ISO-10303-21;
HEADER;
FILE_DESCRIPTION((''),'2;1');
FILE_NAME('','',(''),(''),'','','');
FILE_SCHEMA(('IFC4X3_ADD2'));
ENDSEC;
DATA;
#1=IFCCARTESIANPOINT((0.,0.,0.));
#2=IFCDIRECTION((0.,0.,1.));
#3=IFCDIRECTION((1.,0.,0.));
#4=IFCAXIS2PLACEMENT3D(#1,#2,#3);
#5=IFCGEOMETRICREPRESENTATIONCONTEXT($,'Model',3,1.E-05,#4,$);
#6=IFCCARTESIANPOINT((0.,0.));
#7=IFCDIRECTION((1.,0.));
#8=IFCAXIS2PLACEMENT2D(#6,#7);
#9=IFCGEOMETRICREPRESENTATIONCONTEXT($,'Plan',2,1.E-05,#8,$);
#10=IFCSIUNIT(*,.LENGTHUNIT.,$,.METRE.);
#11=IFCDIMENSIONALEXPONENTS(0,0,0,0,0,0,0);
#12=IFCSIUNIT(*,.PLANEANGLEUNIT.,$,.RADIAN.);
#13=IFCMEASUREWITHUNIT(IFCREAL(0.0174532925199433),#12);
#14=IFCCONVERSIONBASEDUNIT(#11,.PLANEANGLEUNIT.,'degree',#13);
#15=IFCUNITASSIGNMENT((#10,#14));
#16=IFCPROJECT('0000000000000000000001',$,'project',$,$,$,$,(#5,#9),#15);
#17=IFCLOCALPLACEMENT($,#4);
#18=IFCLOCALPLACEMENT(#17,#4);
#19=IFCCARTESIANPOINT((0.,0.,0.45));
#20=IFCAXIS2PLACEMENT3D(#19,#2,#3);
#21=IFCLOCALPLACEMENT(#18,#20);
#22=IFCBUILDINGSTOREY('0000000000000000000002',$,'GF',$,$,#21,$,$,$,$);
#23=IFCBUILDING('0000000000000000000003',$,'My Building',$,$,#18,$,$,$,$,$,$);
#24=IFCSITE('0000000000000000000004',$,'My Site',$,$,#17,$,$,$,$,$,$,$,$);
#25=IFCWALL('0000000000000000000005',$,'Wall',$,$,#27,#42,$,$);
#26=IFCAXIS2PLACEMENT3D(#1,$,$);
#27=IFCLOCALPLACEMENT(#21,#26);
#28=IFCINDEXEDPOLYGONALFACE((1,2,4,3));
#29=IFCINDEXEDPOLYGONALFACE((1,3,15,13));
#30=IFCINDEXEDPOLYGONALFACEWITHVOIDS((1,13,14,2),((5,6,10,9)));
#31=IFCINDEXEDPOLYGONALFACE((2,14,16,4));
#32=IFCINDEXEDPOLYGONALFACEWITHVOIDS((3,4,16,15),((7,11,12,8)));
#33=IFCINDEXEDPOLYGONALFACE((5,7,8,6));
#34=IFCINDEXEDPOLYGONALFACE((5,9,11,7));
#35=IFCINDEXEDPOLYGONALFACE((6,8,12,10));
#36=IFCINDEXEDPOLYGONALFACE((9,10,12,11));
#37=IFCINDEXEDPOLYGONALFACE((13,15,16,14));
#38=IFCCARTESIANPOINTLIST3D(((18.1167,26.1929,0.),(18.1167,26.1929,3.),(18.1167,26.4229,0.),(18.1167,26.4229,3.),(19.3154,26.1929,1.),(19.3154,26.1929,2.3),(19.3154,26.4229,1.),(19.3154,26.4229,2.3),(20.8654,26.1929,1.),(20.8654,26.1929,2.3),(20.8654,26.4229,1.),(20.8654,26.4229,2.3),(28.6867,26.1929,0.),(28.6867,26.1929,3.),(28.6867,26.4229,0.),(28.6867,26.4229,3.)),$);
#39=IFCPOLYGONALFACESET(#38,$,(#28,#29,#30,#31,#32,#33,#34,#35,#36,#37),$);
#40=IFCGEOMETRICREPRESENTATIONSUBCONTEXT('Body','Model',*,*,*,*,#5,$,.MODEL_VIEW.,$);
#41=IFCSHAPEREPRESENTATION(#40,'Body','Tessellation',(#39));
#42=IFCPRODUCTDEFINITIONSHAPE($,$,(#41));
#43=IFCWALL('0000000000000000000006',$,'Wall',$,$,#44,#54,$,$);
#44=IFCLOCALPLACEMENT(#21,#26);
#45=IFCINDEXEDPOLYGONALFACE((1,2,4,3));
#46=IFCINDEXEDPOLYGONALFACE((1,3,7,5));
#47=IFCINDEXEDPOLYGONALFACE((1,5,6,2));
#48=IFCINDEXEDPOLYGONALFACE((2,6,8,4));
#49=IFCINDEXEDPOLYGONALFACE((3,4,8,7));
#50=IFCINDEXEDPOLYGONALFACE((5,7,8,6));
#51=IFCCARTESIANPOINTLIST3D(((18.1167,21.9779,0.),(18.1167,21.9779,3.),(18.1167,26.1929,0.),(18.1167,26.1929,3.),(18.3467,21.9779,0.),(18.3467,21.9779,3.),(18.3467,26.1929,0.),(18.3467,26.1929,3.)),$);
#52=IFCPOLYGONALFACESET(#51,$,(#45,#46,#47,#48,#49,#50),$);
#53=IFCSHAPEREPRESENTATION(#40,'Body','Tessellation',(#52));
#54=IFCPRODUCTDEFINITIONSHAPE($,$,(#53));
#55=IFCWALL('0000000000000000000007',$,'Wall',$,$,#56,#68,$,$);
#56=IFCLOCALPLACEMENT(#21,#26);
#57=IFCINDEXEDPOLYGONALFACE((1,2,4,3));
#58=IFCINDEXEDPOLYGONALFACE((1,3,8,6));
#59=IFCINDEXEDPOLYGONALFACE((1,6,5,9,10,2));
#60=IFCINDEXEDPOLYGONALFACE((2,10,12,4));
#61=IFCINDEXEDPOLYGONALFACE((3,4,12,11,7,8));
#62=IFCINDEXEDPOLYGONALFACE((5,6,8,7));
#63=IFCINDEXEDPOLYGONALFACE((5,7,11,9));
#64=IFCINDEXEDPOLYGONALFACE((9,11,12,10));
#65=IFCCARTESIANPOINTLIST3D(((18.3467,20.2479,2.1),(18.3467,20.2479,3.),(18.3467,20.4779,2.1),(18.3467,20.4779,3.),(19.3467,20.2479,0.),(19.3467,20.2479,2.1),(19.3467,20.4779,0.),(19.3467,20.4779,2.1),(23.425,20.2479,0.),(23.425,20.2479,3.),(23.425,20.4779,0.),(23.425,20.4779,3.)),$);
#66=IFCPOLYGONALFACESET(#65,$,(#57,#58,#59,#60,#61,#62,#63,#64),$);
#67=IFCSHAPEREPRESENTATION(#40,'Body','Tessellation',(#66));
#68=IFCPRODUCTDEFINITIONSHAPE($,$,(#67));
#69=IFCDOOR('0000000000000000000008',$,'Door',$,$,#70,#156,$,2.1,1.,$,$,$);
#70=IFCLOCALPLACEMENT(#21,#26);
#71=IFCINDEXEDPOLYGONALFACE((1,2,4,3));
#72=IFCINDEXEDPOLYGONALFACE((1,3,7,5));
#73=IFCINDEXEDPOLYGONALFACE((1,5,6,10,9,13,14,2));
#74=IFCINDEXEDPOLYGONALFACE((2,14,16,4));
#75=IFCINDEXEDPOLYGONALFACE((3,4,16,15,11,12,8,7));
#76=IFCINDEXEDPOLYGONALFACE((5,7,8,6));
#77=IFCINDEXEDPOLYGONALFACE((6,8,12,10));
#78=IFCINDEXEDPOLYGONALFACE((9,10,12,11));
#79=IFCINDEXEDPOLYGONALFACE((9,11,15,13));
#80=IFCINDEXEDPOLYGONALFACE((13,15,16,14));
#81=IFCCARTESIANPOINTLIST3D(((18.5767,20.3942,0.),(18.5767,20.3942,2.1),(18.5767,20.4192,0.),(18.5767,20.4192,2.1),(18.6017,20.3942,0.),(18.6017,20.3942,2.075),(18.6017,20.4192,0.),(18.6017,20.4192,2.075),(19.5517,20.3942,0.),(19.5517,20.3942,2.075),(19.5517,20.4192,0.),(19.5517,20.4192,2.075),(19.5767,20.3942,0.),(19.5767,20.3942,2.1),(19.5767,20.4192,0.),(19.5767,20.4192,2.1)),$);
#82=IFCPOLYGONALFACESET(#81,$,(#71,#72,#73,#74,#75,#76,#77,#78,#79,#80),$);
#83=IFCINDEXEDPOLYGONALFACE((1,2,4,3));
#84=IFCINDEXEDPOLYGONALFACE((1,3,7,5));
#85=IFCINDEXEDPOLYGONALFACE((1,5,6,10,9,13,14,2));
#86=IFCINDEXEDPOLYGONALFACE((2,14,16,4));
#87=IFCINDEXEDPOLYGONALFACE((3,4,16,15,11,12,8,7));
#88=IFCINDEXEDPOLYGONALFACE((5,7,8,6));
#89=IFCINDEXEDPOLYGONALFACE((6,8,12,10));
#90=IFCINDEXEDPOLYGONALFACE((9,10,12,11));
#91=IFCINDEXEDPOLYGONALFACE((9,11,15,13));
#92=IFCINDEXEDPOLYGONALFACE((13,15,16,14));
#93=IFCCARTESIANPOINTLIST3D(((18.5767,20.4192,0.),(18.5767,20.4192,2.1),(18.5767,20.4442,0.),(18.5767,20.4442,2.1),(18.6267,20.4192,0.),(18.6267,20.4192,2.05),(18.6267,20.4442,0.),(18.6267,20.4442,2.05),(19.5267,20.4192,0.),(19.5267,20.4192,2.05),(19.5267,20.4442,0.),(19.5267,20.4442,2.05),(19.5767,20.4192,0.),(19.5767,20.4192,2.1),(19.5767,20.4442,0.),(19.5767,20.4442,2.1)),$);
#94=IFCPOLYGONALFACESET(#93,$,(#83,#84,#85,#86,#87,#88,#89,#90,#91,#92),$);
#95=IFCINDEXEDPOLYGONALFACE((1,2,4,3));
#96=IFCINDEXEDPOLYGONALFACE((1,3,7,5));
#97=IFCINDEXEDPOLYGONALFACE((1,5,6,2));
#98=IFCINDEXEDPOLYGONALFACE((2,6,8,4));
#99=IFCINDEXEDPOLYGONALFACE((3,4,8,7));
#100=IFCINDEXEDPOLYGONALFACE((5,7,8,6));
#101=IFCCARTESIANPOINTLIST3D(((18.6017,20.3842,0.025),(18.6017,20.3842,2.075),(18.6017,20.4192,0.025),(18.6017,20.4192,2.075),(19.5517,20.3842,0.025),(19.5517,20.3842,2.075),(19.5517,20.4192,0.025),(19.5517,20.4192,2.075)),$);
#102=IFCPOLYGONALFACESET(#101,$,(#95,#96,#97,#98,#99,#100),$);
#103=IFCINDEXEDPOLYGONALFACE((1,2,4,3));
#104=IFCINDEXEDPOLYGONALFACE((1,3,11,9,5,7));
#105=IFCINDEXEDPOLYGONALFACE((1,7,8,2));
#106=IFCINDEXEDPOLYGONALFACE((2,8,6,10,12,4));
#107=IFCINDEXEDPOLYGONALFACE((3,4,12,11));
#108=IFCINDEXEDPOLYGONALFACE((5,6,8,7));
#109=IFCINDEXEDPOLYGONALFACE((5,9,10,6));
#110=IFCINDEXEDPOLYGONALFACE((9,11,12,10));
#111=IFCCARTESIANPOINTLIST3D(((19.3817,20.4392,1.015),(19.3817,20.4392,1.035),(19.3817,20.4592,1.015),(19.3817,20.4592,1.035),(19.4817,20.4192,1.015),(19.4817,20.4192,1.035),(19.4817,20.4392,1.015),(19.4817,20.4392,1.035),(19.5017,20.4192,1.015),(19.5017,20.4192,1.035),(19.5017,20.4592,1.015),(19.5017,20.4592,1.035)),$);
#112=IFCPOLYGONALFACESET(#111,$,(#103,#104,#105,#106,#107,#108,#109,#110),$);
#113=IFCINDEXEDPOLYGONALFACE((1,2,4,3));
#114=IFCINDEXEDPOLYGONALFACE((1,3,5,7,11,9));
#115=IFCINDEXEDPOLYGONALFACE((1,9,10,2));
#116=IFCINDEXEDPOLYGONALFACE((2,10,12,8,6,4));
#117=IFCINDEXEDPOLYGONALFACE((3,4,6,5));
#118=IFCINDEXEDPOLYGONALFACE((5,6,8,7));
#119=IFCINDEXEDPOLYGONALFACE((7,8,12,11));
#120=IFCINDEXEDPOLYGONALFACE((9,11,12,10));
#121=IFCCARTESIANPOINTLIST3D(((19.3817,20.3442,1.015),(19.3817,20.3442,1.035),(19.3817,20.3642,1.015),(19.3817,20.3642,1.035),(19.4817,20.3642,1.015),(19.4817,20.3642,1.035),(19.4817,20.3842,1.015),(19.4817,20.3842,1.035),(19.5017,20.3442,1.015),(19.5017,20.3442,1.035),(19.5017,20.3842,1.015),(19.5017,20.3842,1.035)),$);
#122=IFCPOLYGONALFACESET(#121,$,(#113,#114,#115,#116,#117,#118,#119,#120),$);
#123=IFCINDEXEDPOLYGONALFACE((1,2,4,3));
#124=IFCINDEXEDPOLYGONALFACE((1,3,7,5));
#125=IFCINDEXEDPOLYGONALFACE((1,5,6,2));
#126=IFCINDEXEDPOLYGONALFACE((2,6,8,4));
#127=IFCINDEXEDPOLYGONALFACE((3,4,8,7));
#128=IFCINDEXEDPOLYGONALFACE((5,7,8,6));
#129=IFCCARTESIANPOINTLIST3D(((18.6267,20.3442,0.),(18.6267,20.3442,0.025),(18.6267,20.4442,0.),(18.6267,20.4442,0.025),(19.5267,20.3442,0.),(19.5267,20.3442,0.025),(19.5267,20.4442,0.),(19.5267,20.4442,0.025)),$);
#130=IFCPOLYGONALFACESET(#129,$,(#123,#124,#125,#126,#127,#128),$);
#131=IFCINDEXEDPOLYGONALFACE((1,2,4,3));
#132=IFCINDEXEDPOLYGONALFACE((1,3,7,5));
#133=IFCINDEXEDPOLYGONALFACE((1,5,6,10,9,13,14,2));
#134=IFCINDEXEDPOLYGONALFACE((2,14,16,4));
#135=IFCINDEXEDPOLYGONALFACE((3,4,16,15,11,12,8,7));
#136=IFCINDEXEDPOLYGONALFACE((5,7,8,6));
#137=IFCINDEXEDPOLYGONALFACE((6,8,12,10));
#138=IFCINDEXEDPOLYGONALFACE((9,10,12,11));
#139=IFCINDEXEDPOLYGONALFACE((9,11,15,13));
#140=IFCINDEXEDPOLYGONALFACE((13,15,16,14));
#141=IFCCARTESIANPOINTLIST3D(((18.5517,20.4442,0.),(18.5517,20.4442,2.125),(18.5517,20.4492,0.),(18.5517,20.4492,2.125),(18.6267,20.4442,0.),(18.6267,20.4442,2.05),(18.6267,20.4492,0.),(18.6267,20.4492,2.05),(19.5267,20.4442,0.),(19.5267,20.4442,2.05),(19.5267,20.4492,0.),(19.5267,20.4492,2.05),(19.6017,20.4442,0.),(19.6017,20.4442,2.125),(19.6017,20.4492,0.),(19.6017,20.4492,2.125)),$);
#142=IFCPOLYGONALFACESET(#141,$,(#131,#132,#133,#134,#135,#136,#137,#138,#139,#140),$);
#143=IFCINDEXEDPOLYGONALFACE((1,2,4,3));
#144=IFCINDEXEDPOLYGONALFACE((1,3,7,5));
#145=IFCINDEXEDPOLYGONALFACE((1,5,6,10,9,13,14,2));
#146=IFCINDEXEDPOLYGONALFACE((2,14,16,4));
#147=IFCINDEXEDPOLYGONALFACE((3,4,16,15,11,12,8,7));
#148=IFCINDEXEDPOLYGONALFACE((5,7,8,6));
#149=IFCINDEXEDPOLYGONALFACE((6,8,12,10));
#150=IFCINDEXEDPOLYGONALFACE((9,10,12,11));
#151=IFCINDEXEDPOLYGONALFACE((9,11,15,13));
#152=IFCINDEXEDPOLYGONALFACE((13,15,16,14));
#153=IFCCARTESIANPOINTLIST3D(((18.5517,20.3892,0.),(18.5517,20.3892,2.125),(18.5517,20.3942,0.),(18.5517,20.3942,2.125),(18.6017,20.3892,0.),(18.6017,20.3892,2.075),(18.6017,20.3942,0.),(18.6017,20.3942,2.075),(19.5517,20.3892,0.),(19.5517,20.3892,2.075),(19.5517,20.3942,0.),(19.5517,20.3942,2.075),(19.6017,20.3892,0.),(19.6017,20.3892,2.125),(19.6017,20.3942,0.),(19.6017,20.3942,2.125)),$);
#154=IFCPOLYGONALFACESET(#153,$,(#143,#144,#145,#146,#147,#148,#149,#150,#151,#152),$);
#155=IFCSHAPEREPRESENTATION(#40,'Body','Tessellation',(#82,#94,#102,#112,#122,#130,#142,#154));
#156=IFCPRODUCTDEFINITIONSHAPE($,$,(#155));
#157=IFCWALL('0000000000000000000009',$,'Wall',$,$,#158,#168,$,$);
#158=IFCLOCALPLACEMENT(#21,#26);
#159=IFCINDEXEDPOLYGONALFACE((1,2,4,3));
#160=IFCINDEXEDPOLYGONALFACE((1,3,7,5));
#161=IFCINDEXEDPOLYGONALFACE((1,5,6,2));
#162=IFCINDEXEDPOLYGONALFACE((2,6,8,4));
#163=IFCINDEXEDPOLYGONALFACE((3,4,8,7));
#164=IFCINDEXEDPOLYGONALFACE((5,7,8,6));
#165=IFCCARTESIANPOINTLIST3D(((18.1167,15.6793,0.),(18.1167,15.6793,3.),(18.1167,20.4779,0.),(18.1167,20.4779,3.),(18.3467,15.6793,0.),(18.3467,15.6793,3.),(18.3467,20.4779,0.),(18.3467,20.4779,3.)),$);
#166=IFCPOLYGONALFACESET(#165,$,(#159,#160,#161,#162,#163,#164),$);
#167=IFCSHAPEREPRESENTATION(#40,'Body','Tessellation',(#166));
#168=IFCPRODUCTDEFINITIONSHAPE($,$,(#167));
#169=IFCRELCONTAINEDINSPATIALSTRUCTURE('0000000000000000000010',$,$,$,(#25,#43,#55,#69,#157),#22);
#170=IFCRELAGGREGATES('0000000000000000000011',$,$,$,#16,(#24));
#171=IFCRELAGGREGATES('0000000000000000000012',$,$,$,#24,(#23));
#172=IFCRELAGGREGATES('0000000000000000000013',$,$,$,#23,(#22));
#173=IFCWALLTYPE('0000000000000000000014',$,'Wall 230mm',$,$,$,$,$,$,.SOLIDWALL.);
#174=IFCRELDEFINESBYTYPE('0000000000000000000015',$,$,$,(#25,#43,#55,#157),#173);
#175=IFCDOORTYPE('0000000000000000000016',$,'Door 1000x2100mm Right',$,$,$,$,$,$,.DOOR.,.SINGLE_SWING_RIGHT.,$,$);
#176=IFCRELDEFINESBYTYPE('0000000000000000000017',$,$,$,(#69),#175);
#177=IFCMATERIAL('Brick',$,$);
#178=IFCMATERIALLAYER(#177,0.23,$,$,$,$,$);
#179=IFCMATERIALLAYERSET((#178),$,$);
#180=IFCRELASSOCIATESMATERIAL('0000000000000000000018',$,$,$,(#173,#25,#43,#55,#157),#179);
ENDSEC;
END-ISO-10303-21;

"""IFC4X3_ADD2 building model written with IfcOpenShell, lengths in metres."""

from ifc_helpers import new_model, entity, si_unit, converted_unit, frame, origin_with_axes, origin_2d_with_axis, place, context, subcontext, project, spatial, line, indexed_curve, outline, extrude, shape, source, transform, mapped, material, layer, layer_set, layer_usage, type_object, type_shapes, element, fill, save


model = new_model("IFC4X3_ADD2")

# Units and contexts
model_context = context("Model", 3, precision=1e-05, world=origin_with_axes())
plan_context = context("Plan", 2, precision=1e-05, world=origin_2d_with_axis())
body_context_1 = subcontext(model_context, "Body", "Model", "MODEL_VIEW")
body_context_2 = subcontext(plan_context, "Body", "Plan", "PLAN_VIEW")
ifc_project = project(units=[si_unit("LENGTHUNIT", "METRE"), converted_unit("PLANEANGLEUNIT", "degree", entity("IfcReal", 0.0174532925199433), si_unit("PLANEANGLEUNIT", "RADIAN"), dimensions=[0, 0, 0, 0, 0, 0, 0])], contexts=[model_context, plan_context])

# Site, building, storey
site_placement = place(None, origin_with_axes())
site = spatial("IfcSite", under=ifc_project, at=site_placement, Name="My Site")
building_placement = place(site_placement, origin_with_axes())
building = spatial("IfcBuilding", under=site, at=building_placement, Name="My Building")
storey_placement = place(building_placement, frame((0.0, 0.0, 0.45), z_axis=(0.0, 0.0, 1.0), x_axis=(1.0, 0.0, 0.0)))
storey = spatial("IfcBuildingStorey", under=building, at=storey_placement, Name="GF")

# Wall, opening
ifc_material = material(Name="Brick")
ifc_layer_1 = layer(ifc_material, 0.23)
ifc_layer_set_1 = layer_set([ifc_layer_1])
ifc_layer_usage_1 = layer_usage(ifc_layer_set_1, "AXIS2", "POSITIVE", 0.0)
wall_type_1 = type_object("IfcWallType", Name="Wall 230mm", PredefinedType="SOLIDWALL", material=ifc_layer_set_1)
wall_1_placement = place(storey_placement, frame((18.1167, 26.1929, 0.0), z_axis=(0.0, 0.0, 1.0), x_axis=(1.0, 0.0, 0.0)))
wall_1 = element("IfcWall", 1, at=wall_1_placement, inside=storey, type_object=wall_type_1, material=ifc_layer_usage_1, Name="Wall", context=body_context_1, shape_type="SweptSolid", body=[
    extrude(outline(indexed_curve([(0.0, 0.0), (0.0, 0.23), (10.57, 0.23), (10.57, 0.0), (0.0, 0.0)], self_intersect=False)), origin_with_axes(), (0.0, 0.0, 1.0), 3.0),
])
shared_shape_1 = source(origin_with_axes(), body_context_1, "Body", "SweptSolid", [
    extrude(outline(indexed_curve([(0.0, 0.0), (1.55, 0.0), (1.55, 1.3), (0.0, 1.3)], segments=[line(1, 2, 3, 4, 1)])), frame((-0.775, -0.6, 0.0), z_axis=(0.0, -1.0, 0.0), x_axis=(1.0, 0.0, 0.0)), (0.0, 0.0, -1.0), 1.2),
])
opening_1_placement = place(wall_1_placement, frame((1.9737, 0.215, 1.0), z_axis=(0.0, 0.0, 1.0), x_axis=(-1.0, 0.0, 0.0)))
element("IfcOpeningElement", 2, at=opening_1_placement, cuts=wall_1, PredefinedType="OPENING", context=body_context_1, shape_type="MappedRepresentation", body=[
    mapped(shared_shape_1, transform((0.0, 0.0, 0.0), x_axis=(1.0, 0.0, 0.0), y_axis=(0.0, 1.0, 0.0), z_axis=(0.0, 0.0, 1.0), scale=1.0)),
])

# Wall
ifc_layer_usage_2 = layer_usage(ifc_layer_set_1, "AXIS2", "POSITIVE", 0.0)
wall_2_placement = place(storey_placement, frame((18.3467, 21.9779, 0.0), z_axis=(0.0, 0.0, 1.0), x_axis=(0.0, 1.0, 0.0)))
element("IfcWall", 3, at=wall_2_placement, inside=storey, type_object=wall_type_1, material=ifc_layer_usage_2, Name="Wall", context=body_context_1, shape_type="SweptSolid", body=[
    extrude(outline(indexed_curve([(0.0, 0.0), (0.0, 0.23), (4.215, 0.23), (4.215, 0.0), (0.0, 0.0)], self_intersect=False)), origin_with_axes(), (0.0, 0.0, 1.0), 3.0),
])

# Shared definitions
shared_shape_2 = source(origin_with_axes(), body_context_1, "Body", "SweptSolid", [
    extrude(outline(indexed_curve([(0.0, 0.0), (1.0, 0.0), (1.0, 2.1), (0.0, 2.1)], segments=[line(1, 2, 3, 4, 1)])), frame((0.0, -0.6, 0.0), z_axis=(0.0, -1.0, 0.0), x_axis=(1.0, 0.0, 0.0)), (0.0, 0.0, -1.0), 1.2),
])
door_type_1 = type_object("IfcDoorType", Name="Door 1000x2100mm Right", OperationType="SINGLE_SWING_RIGHT", PredefinedType="DOOR")
shared_shape_3 = source(origin_with_axes(), body_context_1, "Body", "SweptSolid", [
    extrude(outline(indexed_curve([(0.0, 0.0), (0.0, 2.1), (1.0, 2.1), (1.0, 0.0), (0.975, 0.0), (0.975, 2.075), (0.025, 2.075), (0.025, 0.0)], segments=[line(1, 2, 3, 4, 5, 6, 7, 8, 1)])), frame((0.0, 0.025, 0.0), z_axis=(0.0, -1.0, 0.0), x_axis=(1.0, 0.0, 0.0)), (0.0, 0.0, -1.0), 0.025),
    extrude(outline(indexed_curve([(0.0, 0.0), (0.0, 2.1), (1.0, 2.1), (1.0, 0.0), (0.95, 0.0), (0.95, 2.05), (0.05, 2.05), (0.05, 0.0)], segments=[line(1, 2, 3, 4, 5, 6, 7, 8, 1)])), frame((0.0, 0.0, 0.0), z_axis=(0.0, -1.0, 0.0), x_axis=(1.0, 0.0, 0.0)), (0.0, 0.0, -1.0), 0.025),
    extrude(outline(indexed_curve([(0.0, 0.0), (0.95, 0.0), (0.95, 0.035), (0.0, 0.035)], segments=[line(1, 2, 3, 4, 1)])), frame((0.025, 0.025, 0.025), z_axis=(0.0, 0.0, 1.0), x_axis=(1.0, 0.0, 0.0)), (0.0, 0.0, 1.0), 2.05),
    extrude(outline(indexed_curve([(0.0, 0.0), (0.0, -0.04), (0.12, -0.04), (0.12, -0.02), (0.02, -0.02), (0.02, 0.0)], segments=[line(1, 2, 3, 4, 5, 6, 1)])), frame((0.075, 0.025, 1.015), z_axis=(0.0, 0.0, 1.0), x_axis=(1.0, 0.0, 0.0)), (0.0, 0.0, 1.0), 0.02),
    extrude(outline(indexed_curve([(0.0, 0.0), (0.0, 0.04), (0.12, 0.04), (0.12, 0.02), (0.02, 0.02), (0.02, 0.0)], segments=[line(1, 2, 3, 4, 5, 6, 1)])), frame((0.075, 0.06, 1.015), z_axis=(0.0, 0.0, 1.0), x_axis=(1.0, 0.0, 0.0)), (0.0, 0.0, 1.0), 0.02),
    extrude(outline(indexed_curve([(0.0, 0.0), (0.9, 0.0), (0.9, 0.1), (0.0, 0.1)], segments=[line(1, 2, 3, 4, 1)])), frame((0.05, 0.0, 0.0), z_axis=(0.0, 0.0, 1.0), x_axis=(1.0, 0.0, 0.0)), (0.0, 0.0, 1.0), 0.025),
    extrude(outline(indexed_curve([(0.0, 0.0), (0.0, 2.125), (1.05, 2.125), (1.05, 0.0), (0.975, 0.0), (0.975, 2.05), (0.075, 2.05), (0.075, 0.0)], segments=[line(1, 2, 3, 4, 5, 6, 7, 8, 1)])), frame((-0.025, -0.005, 0.0), z_axis=(0.0, -1.0, 0.0), x_axis=(1.0, 0.0, 0.0)), (0.0, 0.0, -1.0), 0.005),
    extrude(outline(indexed_curve([(0.0, 0.0), (0.0, 2.125), (1.05, 2.125), (1.05, 0.0), (1.0, 0.0), (1.0, 2.075), (0.05, 2.075), (0.05, 0.0)], segments=[line(1, 2, 3, 4, 5, 6, 7, 8, 1)])), frame((-0.025, 0.05, 0.0), z_axis=(0.0, -1.0, 0.0), x_axis=(1.0, 0.0, 0.0)), (0.0, 0.0, -1.0), 0.005),
])
shared_shape_4 = source(origin_with_axes(), body_context_2, "Body", "Curve2D", [
    entity("IfcIndexedPolyCurve", entity("IfcCartesianPointList2D", [[0.0, 0.0], [0.0, 0.05], [0.025, 0.05], [0.025, 0.025], [0.05, 0.025], [0.05, 0.0]]), [entity("IfcLineIndex", [1, 2, 3, 4, 5, 6, 1])]),
    entity("IfcIndexedPolyCurve", entity("IfcCartesianPointList2D", [[1.0, 0.0], [1.0, 0.05], [0.975, 0.05], [0.975, 0.025], [0.95, 0.025], [0.95, 0.0]]), [entity("IfcLineIndex", [1, 2, 3, 4, 5, 6, 1])]),
    entity("IfcTrimmedCurve", entity("IfcEllipse", entity("IfcAxis2Placement2D", entity("IfcCartesianPoint", [0.94, 0.05]), entity("IfcDirection", [1.0, 0.0])), 0.915, 0.95), [entity("IfcCartesianPoint", [0.94, 1.0])], [entity("IfcCartesianPoint", [0.025, 0.05])], True, "CARTESIAN"),
    entity("IfcIndexedPolyCurve", entity("IfcCartesianPointList2D", [[0.975, 0.05], [0.94, 0.05], [0.94, 1.0], [0.975, 1.0]]), [entity("IfcLineIndex", [1, 2, 3, 4, 1])]),
])
type_shapes(door_type_1, [shared_shape_3, shared_shape_4])

# Wall, opening, door
ifc_layer_usage_3 = layer_usage(ifc_layer_set_1, "AXIS2", "POSITIVE", 0.0)
wall_3_placement = place(storey_placement, frame((18.3467, 20.2479, 0.0), z_axis=(0.0, 0.0, 1.0), x_axis=(1.0, 0.0, 0.0)))
wall_3 = element("IfcWall", 4, at=wall_3_placement, inside=storey, type_object=wall_type_1, material=ifc_layer_usage_3, Name="Wall", context=body_context_1, shape_type="SweptSolid", body=[
    extrude(outline(indexed_curve([(0.0, 0.0), (0.0, 0.23), (5.0783, 0.23), (5.0783, 0.0), (0.0, 0.0)], self_intersect=False)), origin_with_axes(), (0.0, 0.0, 1.0), 3.0),
])
opening_2_placement = place(wall_3_placement, frame((1.0, 0.1963, 0.0), z_axis=(0.0, 0.0, 1.0), x_axis=(-1.0, 0.0, 0.0)))
opening_2 = element("IfcOpeningElement", 5, at=opening_2_placement, cuts=wall_3, PredefinedType="OPENING", context=body_context_1, shape_type="MappedRepresentation", body=[
    mapped(shared_shape_2, transform((0.0, 0.0, 0.0), x_axis=(1.0, 0.0, 0.0), y_axis=(0.0, 1.0, 0.0), z_axis=(0.0, 0.0, 1.0), scale=1.0)),
])
door_1_placement = place(opening_2_placement, frame((-0.23, 0.0, 0.0), z_axis=(0.0, 0.0, 1.0), x_axis=(1.0, 0.0, 0.0)))
door_1 = element("IfcDoor", 6, at=door_1_placement, inside=storey, type_object=door_type_1, Name="Door", OverallHeight=2.1, OverallWidth=1.0, shapes=[
    shape(body_context_1, "Body", "MappedRepresentation", [mapped(shared_shape_3, transform((0.0, 0.0, 0.0), x_axis=(1.0, 0.0, 0.0), y_axis=(0.0, 1.0, 0.0), z_axis=(0.0, 0.0, 1.0), scale=1.0))]),
    shape(body_context_2, "Body", "MappedRepresentation", [mapped(shared_shape_4, transform((0.0, 0.0, 0.0), x_axis=(1.0, 0.0, 0.0), y_axis=(0.0, 1.0, 0.0), z_axis=(0.0, 0.0, 1.0), scale=1.0))]),
])
fill(opening_2, door_1)

# Wall
ifc_layer_usage_4 = layer_usage(ifc_layer_set_1, "AXIS2", "POSITIVE", 0.0)
wall_4_placement = place(storey_placement, frame((18.3467, 15.6793, 0.0), z_axis=(0.0, 0.0, 1.0), x_axis=(0.0, 1.0, 0.0)))
element("IfcWall", 7, at=wall_4_placement, inside=storey, type_object=wall_type_1, material=ifc_layer_usage_4, Name="Wall", context=body_context_1, shape_type="SweptSolid", body=[
    extrude(outline(indexed_curve([(0.0, 0.0), (0.0, 0.23), (4.7985, 0.23), (4.7985, 0.0), (0.0, 0.0)], self_intersect=False)), origin_with_axes(), (0.0, 0.0, 1.0), 3.0),
])

save(model, "model.ifc")
